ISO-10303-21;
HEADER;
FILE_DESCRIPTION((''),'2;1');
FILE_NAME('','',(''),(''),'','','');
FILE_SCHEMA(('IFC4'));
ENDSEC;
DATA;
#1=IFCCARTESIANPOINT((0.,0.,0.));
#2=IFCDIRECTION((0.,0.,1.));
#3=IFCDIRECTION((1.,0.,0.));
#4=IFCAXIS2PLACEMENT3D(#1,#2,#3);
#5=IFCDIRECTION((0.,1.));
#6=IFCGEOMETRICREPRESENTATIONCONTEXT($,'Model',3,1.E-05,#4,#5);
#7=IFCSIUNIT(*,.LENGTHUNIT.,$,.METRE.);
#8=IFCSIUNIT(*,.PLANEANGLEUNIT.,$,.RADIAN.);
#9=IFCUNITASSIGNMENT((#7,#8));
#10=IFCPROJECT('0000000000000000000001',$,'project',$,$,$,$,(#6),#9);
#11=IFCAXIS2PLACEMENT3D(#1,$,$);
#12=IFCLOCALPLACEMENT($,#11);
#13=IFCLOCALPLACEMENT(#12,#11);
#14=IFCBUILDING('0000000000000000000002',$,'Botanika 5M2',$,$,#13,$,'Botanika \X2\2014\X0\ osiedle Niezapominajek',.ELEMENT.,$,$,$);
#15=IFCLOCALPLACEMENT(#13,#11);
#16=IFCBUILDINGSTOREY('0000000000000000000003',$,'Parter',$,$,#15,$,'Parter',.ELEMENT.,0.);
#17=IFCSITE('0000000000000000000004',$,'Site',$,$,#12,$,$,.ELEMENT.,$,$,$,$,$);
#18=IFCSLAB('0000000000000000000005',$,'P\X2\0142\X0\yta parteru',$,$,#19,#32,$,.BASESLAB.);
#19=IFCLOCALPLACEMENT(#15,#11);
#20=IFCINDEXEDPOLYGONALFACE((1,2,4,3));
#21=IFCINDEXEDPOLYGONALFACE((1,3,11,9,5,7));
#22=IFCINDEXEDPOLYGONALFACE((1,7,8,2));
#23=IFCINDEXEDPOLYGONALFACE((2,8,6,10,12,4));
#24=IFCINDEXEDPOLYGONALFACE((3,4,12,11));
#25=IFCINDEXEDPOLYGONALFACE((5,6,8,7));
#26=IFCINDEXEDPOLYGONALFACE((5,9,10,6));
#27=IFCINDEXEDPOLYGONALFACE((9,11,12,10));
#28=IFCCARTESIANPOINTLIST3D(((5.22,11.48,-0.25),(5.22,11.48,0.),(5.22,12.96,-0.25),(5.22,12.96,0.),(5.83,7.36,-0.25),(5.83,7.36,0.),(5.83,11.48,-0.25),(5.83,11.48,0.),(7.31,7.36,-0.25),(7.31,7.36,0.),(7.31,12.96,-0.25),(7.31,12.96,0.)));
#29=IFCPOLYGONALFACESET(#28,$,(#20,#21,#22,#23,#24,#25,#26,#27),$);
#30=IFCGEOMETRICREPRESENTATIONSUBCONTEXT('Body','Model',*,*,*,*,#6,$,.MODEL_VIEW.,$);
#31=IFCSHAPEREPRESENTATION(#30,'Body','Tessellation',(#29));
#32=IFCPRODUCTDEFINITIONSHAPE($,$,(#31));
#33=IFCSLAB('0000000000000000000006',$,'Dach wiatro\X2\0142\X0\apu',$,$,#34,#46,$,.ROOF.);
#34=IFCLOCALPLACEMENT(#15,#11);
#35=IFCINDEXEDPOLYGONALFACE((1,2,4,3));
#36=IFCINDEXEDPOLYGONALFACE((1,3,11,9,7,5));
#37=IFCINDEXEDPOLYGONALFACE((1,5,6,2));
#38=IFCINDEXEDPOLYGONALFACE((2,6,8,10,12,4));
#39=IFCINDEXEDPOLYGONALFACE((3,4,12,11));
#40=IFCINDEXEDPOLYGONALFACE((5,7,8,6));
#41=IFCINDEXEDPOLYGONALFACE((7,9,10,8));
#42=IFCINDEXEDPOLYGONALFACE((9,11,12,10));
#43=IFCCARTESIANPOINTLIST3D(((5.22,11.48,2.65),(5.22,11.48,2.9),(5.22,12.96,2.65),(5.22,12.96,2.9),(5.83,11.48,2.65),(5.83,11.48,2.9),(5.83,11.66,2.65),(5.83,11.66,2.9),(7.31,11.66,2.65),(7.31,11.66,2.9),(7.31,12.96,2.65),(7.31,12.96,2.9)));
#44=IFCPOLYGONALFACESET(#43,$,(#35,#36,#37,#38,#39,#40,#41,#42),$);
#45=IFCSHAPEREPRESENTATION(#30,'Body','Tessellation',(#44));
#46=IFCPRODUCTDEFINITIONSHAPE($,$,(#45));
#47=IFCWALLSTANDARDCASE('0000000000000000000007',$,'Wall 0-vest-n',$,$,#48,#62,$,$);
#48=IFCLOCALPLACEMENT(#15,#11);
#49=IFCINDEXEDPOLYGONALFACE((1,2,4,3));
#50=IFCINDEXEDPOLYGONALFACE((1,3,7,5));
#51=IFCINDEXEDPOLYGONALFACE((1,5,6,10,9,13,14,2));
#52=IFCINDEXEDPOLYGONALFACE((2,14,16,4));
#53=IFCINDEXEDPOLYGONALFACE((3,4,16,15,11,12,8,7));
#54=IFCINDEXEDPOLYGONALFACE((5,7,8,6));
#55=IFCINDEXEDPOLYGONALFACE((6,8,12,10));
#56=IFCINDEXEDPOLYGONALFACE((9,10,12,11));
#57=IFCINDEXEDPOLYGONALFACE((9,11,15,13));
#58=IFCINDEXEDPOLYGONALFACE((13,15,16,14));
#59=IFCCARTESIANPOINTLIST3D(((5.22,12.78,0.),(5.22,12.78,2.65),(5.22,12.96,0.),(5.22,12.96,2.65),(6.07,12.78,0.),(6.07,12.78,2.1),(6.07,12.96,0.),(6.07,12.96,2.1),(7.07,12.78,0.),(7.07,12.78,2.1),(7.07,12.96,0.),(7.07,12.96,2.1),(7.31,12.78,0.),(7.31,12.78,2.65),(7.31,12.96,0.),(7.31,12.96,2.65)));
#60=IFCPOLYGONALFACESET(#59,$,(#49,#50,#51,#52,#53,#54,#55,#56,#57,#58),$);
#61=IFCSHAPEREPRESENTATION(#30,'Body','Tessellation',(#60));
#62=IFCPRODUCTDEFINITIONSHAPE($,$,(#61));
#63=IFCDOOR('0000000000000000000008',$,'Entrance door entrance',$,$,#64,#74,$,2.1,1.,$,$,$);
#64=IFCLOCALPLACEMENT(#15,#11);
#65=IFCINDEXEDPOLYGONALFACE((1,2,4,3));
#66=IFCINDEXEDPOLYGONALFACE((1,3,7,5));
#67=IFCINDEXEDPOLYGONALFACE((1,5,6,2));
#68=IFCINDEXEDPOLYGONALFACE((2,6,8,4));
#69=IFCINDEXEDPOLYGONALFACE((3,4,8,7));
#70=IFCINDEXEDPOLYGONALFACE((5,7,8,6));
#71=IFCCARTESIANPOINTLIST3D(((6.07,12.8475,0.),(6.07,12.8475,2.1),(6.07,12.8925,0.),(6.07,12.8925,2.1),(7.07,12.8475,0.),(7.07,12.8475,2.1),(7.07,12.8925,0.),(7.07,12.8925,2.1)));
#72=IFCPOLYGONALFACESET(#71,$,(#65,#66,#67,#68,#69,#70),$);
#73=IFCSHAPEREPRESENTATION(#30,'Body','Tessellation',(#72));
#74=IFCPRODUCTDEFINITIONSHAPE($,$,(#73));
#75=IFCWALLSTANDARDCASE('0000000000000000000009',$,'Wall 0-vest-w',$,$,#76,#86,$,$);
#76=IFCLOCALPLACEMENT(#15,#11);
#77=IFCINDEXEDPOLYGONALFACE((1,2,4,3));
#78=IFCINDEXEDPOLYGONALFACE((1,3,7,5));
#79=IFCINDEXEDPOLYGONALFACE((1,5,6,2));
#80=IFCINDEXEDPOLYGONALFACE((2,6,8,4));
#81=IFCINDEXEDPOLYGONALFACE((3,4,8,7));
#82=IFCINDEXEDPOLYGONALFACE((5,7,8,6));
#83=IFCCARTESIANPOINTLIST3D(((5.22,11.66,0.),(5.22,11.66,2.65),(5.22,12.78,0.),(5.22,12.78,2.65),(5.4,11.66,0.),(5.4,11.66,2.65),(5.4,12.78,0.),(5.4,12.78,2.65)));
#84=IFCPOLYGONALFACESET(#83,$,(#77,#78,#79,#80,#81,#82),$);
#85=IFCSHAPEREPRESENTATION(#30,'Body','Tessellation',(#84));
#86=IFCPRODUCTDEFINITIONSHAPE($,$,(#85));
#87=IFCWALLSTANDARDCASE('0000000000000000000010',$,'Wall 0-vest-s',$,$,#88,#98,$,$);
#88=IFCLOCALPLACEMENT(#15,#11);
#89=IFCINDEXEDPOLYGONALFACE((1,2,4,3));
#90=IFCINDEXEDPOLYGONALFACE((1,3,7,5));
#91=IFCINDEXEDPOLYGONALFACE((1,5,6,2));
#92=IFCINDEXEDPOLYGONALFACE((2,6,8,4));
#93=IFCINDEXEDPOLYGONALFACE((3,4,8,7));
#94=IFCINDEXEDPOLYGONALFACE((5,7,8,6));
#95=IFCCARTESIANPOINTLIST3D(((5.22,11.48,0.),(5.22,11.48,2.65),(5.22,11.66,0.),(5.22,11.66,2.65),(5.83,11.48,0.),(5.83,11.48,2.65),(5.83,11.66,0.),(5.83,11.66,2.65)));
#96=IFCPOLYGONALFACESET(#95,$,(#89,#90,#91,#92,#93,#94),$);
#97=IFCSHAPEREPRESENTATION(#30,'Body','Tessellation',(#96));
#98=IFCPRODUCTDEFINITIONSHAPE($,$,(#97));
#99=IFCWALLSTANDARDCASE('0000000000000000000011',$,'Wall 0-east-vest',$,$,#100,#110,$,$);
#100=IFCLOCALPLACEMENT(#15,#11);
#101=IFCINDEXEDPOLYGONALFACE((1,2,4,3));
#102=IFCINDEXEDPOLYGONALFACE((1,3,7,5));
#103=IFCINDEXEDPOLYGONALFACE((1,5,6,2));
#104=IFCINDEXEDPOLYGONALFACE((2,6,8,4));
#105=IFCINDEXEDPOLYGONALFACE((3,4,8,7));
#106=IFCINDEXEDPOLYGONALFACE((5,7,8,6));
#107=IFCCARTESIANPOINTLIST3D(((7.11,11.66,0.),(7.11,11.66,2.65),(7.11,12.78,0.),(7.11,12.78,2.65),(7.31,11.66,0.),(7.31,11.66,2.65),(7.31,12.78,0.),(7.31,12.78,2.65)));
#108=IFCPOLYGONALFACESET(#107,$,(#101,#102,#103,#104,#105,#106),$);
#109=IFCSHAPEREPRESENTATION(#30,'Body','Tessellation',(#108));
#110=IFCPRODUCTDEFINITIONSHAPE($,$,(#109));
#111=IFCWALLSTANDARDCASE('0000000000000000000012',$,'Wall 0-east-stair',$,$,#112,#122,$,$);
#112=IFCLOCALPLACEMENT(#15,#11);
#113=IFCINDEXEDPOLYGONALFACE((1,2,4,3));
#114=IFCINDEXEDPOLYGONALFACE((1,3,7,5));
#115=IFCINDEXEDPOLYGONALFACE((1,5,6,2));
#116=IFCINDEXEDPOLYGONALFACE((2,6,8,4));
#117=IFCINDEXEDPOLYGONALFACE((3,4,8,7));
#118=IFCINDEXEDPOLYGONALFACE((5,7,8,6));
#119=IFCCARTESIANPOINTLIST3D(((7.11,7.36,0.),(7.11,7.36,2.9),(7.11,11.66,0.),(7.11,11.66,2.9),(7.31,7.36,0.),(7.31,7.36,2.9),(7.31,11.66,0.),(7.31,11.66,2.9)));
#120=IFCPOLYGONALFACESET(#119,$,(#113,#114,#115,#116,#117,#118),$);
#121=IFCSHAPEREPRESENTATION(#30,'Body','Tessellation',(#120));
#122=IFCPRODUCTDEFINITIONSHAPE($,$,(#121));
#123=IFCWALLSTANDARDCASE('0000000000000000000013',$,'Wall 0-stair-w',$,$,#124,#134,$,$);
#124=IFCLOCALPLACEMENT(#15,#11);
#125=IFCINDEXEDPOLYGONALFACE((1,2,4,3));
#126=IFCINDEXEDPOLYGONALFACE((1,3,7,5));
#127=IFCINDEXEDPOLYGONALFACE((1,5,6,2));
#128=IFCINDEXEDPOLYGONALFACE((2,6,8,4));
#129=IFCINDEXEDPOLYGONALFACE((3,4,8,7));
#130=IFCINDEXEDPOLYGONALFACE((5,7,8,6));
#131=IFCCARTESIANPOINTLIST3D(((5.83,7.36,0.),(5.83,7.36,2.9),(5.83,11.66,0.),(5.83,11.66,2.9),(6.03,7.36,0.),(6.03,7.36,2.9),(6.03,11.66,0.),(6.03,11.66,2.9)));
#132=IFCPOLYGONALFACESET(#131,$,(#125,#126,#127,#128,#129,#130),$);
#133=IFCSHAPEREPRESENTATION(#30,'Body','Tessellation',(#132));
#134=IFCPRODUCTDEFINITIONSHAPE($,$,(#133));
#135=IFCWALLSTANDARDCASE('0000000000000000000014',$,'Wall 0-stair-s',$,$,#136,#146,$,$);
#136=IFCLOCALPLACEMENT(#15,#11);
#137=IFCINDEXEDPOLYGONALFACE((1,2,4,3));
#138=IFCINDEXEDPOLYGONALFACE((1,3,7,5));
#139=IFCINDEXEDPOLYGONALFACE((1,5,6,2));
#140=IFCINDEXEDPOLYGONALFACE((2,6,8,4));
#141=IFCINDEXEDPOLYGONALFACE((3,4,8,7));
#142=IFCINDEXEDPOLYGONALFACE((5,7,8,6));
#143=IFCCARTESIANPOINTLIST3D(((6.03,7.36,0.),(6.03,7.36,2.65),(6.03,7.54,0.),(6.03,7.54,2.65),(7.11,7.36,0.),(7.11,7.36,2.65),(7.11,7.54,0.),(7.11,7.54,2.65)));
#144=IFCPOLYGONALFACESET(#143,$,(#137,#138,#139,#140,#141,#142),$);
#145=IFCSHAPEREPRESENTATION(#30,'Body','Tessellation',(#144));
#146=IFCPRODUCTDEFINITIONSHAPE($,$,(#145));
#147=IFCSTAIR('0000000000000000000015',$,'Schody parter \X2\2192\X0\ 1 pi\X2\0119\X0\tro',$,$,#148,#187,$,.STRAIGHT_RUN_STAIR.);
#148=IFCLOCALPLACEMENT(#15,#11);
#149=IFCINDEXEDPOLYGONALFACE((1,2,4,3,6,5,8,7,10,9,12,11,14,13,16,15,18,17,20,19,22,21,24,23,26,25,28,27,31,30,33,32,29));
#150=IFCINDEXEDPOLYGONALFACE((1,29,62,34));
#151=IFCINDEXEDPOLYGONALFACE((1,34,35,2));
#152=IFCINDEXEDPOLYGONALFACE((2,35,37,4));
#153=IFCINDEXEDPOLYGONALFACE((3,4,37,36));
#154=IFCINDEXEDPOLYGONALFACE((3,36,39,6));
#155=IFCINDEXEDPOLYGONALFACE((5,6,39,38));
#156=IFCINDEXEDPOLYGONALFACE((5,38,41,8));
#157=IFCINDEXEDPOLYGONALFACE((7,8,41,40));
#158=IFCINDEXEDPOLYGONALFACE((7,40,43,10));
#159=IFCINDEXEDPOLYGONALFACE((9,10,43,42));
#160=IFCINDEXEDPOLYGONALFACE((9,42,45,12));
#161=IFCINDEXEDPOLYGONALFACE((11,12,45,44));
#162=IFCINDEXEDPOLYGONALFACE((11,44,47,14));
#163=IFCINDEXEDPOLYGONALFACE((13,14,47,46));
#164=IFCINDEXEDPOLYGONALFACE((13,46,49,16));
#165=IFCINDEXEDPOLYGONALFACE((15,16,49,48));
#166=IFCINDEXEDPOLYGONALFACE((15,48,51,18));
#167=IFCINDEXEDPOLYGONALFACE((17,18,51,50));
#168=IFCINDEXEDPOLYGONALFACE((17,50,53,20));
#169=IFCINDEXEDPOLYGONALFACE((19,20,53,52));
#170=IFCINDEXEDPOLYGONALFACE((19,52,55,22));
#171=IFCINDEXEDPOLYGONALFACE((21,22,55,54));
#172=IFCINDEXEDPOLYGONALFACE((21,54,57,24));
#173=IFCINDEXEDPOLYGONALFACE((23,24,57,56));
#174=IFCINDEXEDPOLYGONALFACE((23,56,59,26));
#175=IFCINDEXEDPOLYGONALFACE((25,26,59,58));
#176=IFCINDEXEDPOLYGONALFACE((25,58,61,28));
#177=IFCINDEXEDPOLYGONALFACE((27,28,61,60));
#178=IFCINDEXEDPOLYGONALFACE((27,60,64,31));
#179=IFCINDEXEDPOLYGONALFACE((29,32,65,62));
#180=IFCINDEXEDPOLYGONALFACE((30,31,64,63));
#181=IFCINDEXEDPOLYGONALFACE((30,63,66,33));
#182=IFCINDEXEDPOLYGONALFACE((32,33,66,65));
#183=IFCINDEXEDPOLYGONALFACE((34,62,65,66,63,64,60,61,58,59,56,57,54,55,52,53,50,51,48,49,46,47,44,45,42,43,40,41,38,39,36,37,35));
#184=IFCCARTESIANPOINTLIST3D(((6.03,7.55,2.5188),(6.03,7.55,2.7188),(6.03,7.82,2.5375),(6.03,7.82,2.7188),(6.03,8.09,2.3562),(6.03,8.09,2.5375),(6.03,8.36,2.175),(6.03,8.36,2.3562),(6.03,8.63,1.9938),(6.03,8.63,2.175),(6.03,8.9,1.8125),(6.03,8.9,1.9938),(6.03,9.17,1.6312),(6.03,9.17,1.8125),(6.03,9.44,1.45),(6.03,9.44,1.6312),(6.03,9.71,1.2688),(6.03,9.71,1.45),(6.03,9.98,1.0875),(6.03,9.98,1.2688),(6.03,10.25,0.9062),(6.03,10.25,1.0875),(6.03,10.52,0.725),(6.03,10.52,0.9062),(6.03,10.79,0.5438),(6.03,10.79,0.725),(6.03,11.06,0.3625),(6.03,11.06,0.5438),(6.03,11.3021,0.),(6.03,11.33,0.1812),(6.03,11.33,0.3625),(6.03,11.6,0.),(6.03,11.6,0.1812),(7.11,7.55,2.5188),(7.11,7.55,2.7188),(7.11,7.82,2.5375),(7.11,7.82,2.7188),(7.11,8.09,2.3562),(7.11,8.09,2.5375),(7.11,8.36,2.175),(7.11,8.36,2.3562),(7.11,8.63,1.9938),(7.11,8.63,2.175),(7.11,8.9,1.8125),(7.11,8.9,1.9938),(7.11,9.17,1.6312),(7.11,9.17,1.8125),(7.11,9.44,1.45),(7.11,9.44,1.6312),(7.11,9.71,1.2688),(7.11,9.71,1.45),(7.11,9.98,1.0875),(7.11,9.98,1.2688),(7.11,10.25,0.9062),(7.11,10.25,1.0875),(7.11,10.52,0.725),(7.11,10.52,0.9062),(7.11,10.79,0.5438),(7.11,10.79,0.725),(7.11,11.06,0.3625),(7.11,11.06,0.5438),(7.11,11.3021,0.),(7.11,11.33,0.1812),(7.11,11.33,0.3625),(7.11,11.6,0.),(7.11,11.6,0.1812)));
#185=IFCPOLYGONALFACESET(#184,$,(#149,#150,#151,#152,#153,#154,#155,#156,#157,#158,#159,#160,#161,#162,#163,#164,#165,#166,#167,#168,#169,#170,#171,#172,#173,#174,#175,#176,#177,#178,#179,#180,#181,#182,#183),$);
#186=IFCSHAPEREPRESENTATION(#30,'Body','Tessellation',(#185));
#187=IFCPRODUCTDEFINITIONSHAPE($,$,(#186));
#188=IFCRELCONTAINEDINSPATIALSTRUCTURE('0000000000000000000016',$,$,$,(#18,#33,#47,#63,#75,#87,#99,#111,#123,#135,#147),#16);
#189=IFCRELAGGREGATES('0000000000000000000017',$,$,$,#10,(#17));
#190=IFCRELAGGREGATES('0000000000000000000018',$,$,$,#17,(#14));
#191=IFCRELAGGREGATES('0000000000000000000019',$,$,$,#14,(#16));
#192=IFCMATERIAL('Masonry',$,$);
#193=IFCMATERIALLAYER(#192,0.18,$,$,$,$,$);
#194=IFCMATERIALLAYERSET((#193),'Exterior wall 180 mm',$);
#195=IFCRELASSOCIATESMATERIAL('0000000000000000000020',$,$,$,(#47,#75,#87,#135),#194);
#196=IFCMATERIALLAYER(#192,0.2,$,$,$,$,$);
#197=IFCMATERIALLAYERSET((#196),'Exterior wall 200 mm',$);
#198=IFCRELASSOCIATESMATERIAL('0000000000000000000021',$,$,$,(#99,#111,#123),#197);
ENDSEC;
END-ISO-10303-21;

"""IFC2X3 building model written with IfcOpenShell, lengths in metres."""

from ifc_helpers import new_model, si_unit, direction, frame, frame_2d, origin, origin_with_axes, place, context, subcontext, project, spatial, polyline, rectangle, outline, extrude, material, layer, layer_set, layer_usage, element, fill, save


model = new_model("IFC2X3")

# Units and contexts
model_context = context("Model", 3, precision=1e-05, world=origin_with_axes(), true_north=direction((0.0, 1.0)))
body_context = subcontext(model_context, "Body", "Model", "MODEL_VIEW")
ifc_project = project(units=[si_unit("LENGTHUNIT", "METRE"), si_unit("PLANEANGLEUNIT", "RADIAN")], contexts=[model_context])

# Site, building, storey
site_placement = place(None, origin())
site = spatial("IfcSite", under=ifc_project, at=site_placement, Name="Site", CompositionType="ELEMENT")
building_placement = place(site_placement, origin())
building = spatial("IfcBuilding", under=site, at=building_placement, Name="Botanika 5M2", LongName="Botanika — osiedle Niezapominajek", CompositionType="ELEMENT")
storey_placement = place(building_placement, origin())
storey = spatial("IfcBuildingStorey", under=building, at=storey_placement, Name="Parter", LongName="Parter", CompositionType="ELEMENT", Elevation=0.0)

# Slabs
slab_1_placement = place(storey_placement, frame((0.0, 0.0, -0.25)))
element("IfcSlab", 1, at=slab_1_placement, inside=storey, Name="Płyta parteru", PredefinedType="BASESLAB", context=body_context, shape_type="SweptSolid", body=[
    extrude(outline(polyline([(5.22, 12.96), (7.31, 12.96), (7.31, 7.36), (5.83, 7.36), (5.83, 11.48), (5.22, 11.48), (5.22, 12.96)])), origin_with_axes(), (0.0, 0.0, 1.0), 0.25),
])
slab_2_placement = place(storey_placement, frame((0.0, 0.0, 2.65)))
element("IfcSlab", 2, at=slab_2_placement, inside=storey, Name="Dach wiatrołapu", PredefinedType="ROOF", context=body_context, shape_type="SweptSolid", body=[
    extrude(outline(polyline([(5.22, 12.96), (7.31, 12.96), (7.31, 11.66), (5.83, 11.66), (5.83, 11.48), (5.22, 11.48), (5.22, 12.96)])), origin_with_axes(), (0.0, 0.0, 1.0), 0.25),
])

# Wall, opening, door
ifc_material = material(Name="Masonry")
ifc_layer_1 = layer(ifc_material, 0.18)
ifc_layer_set_1 = layer_set([ifc_layer_1], Name="Exterior wall 180 mm")
ifc_layer_usage_1 = layer_usage(ifc_layer_set_1, "AXIS2", "POSITIVE", -0.09)
wall_1_placement = place(storey_placement, frame((5.22, 12.87, 0.0)))
wall_1 = element("IfcWallStandardCase", 3, at=wall_1_placement, inside=storey, material=ifc_layer_usage_1, Name="Wall 0-vest-n", context=body_context, shape_type="SweptSolid", body=[
    extrude(rectangle(XDim=2.09, YDim=0.18, at=frame_2d((1.045, 0.0))), origin_with_axes(), (0.0, 0.0, 1.0), 2.65),
])
opening_placement = place(wall_1_placement, frame((0.85, 0.14, 0.0), z_axis=(0.0, -1.0, 0.0), x_axis=(1.0, 0.0, 0.0)))
opening = element("IfcOpeningElement", 4, at=opening_placement, cuts=wall_1, context=body_context, shape_type="SweptSolid", body=[
    extrude(rectangle(XDim=1.0, YDim=2.1, at=frame_2d((0.5, 1.05))), origin_with_axes(), (0.0, 0.0, 1.0), 0.28),
])
door_placement = place(wall_1_placement, frame((0.85, 0.0, 0.0)))
door = element("IfcDoor", 5, at=door_placement, inside=storey, Name="Entrance door entrance", OverallHeight=2.1, OverallWidth=1.0, context=body_context, shape_type="SweptSolid", body=[
    extrude(rectangle(XDim=1.0, YDim=0.045, at=frame_2d((0.5, 0.0))), origin_with_axes(), (0.0, 0.0, 1.0), 2.1),
])
fill(opening, door)

# Walls
wall_2_placement = place(storey_placement, frame((5.31, 12.78, 0.0), z_axis=(0.0, 0.0, 1.0), x_axis=(0.0, -1.0, 0.0)))
element("IfcWallStandardCase", 6, at=wall_2_placement, inside=storey, material=ifc_layer_usage_1, Name="Wall 0-vest-w", context=body_context, shape_type="SweptSolid", body=[
    extrude(rectangle(XDim=1.12, YDim=0.18, at=frame_2d((0.56, 0.0))), origin_with_axes(), (0.0, 0.0, 1.0), 2.65),
])
wall_3_placement = place(storey_placement, frame((5.22, 11.57, 0.0)))
element("IfcWallStandardCase", 7, at=wall_3_placement, inside=storey, material=ifc_layer_usage_1, Name="Wall 0-vest-s", context=body_context, shape_type="SweptSolid", body=[
    extrude(rectangle(XDim=0.61, YDim=0.18, at=frame_2d((0.305, 0.0))), origin_with_axes(), (0.0, 0.0, 1.0), 2.65),
])
ifc_layer_2 = layer(ifc_material, 0.2)
ifc_layer_set_2 = layer_set([ifc_layer_2], Name="Exterior wall 200 mm")
ifc_layer_usage_2 = layer_usage(ifc_layer_set_2, "AXIS2", "POSITIVE", -0.1)
wall_4_placement = place(storey_placement, frame((7.21, 12.78, 0.0), z_axis=(0.0, 0.0, 1.0), x_axis=(0.0, -1.0, 0.0)))
element("IfcWallStandardCase", 8, at=wall_4_placement, inside=storey, material=ifc_layer_usage_2, Name="Wall 0-east-vest", context=body_context, shape_type="SweptSolid", body=[
    extrude(rectangle(XDim=1.12, YDim=0.2, at=frame_2d((0.56, 0.0))), origin_with_axes(), (0.0, 0.0, 1.0), 2.65),
])
for number, where, z_axis, x_axis, name in (
    (9, (7.21, 11.66, 0.0), (0.0, 0.0, 1.0), (0.0, -1.0, 0.0), "Wall 0-east-stair"),
    (10, (5.93, 11.66, 0.0), (0.0, 0.0, 1.0), (0.0, -1.0, 0.0), "Wall 0-stair-w"),
):
    element("IfcWallStandardCase", number, at=place(storey_placement, frame(where, z_axis=z_axis, x_axis=x_axis)), inside=storey, material=ifc_layer_usage_2, Name=name, context=body_context, shape_type="SweptSolid", body=[
        extrude(rectangle(XDim=4.3, YDim=0.2, at=frame_2d((2.15, 0.0))), origin_with_axes(), (0.0, 0.0, 1.0), 2.9),
    ])
wall_5_placement = place(storey_placement, frame((6.03, 7.45, 0.0)))
element("IfcWallStandardCase", 11, at=wall_5_placement, inside=storey, material=ifc_layer_usage_1, Name="Wall 0-stair-s", context=body_context, shape_type="SweptSolid", body=[
    extrude(rectangle(XDim=1.08, YDim=0.18, at=frame_2d((0.54, 0.0))), origin_with_axes(), (0.0, 0.0, 1.0), 2.65),
])

# Stair
stair_placement = place(storey_placement, frame((7.11, 11.6, 0.0), z_axis=(-1.0, 0.0, 0.0), x_axis=(0.0, -1.0, 0.0)))
element("IfcStair", 12, at=stair_placement, inside=storey, Name="Schody parter → 1 piętro", ShapeType="STRAIGHT_RUN_STAIR", context=body_context, shape_type="SweptSolid", body=[
    extrude(outline(polyline([(0.0, 0.0), (0.0, 0.1812), (0.27, 0.1812), (0.27, 0.3625), (0.54, 0.3625), (0.54, 0.5437), (0.81, 0.5437), (0.81, 0.725), (1.08, 0.725), (1.08, 0.9062), (1.35, 0.9062), (1.35, 1.0875), (1.62, 1.0875), (1.62, 1.2688), (1.89, 1.2688), (1.89, 1.45), (2.16, 1.45), (2.16, 1.6313), (2.43, 1.6313), (2.43, 1.8125), (2.7, 1.8125), (2.7, 1.9937), (2.97, 1.9937), (2.97, 2.175), (3.24, 2.175), (3.24, 2.3563), (3.51, 2.3563), (3.51, 2.5375), (3.78, 2.5375), (3.78, 2.7188), (4.05, 2.7188), (4.05, 2.9), (4.05, 2.5187), (0.2979, 0.0), (0.0, 0.0)])), origin_with_axes(), (0.0, 0.0, 1.0), 1.08),
])

save(model, "model.ifc")
